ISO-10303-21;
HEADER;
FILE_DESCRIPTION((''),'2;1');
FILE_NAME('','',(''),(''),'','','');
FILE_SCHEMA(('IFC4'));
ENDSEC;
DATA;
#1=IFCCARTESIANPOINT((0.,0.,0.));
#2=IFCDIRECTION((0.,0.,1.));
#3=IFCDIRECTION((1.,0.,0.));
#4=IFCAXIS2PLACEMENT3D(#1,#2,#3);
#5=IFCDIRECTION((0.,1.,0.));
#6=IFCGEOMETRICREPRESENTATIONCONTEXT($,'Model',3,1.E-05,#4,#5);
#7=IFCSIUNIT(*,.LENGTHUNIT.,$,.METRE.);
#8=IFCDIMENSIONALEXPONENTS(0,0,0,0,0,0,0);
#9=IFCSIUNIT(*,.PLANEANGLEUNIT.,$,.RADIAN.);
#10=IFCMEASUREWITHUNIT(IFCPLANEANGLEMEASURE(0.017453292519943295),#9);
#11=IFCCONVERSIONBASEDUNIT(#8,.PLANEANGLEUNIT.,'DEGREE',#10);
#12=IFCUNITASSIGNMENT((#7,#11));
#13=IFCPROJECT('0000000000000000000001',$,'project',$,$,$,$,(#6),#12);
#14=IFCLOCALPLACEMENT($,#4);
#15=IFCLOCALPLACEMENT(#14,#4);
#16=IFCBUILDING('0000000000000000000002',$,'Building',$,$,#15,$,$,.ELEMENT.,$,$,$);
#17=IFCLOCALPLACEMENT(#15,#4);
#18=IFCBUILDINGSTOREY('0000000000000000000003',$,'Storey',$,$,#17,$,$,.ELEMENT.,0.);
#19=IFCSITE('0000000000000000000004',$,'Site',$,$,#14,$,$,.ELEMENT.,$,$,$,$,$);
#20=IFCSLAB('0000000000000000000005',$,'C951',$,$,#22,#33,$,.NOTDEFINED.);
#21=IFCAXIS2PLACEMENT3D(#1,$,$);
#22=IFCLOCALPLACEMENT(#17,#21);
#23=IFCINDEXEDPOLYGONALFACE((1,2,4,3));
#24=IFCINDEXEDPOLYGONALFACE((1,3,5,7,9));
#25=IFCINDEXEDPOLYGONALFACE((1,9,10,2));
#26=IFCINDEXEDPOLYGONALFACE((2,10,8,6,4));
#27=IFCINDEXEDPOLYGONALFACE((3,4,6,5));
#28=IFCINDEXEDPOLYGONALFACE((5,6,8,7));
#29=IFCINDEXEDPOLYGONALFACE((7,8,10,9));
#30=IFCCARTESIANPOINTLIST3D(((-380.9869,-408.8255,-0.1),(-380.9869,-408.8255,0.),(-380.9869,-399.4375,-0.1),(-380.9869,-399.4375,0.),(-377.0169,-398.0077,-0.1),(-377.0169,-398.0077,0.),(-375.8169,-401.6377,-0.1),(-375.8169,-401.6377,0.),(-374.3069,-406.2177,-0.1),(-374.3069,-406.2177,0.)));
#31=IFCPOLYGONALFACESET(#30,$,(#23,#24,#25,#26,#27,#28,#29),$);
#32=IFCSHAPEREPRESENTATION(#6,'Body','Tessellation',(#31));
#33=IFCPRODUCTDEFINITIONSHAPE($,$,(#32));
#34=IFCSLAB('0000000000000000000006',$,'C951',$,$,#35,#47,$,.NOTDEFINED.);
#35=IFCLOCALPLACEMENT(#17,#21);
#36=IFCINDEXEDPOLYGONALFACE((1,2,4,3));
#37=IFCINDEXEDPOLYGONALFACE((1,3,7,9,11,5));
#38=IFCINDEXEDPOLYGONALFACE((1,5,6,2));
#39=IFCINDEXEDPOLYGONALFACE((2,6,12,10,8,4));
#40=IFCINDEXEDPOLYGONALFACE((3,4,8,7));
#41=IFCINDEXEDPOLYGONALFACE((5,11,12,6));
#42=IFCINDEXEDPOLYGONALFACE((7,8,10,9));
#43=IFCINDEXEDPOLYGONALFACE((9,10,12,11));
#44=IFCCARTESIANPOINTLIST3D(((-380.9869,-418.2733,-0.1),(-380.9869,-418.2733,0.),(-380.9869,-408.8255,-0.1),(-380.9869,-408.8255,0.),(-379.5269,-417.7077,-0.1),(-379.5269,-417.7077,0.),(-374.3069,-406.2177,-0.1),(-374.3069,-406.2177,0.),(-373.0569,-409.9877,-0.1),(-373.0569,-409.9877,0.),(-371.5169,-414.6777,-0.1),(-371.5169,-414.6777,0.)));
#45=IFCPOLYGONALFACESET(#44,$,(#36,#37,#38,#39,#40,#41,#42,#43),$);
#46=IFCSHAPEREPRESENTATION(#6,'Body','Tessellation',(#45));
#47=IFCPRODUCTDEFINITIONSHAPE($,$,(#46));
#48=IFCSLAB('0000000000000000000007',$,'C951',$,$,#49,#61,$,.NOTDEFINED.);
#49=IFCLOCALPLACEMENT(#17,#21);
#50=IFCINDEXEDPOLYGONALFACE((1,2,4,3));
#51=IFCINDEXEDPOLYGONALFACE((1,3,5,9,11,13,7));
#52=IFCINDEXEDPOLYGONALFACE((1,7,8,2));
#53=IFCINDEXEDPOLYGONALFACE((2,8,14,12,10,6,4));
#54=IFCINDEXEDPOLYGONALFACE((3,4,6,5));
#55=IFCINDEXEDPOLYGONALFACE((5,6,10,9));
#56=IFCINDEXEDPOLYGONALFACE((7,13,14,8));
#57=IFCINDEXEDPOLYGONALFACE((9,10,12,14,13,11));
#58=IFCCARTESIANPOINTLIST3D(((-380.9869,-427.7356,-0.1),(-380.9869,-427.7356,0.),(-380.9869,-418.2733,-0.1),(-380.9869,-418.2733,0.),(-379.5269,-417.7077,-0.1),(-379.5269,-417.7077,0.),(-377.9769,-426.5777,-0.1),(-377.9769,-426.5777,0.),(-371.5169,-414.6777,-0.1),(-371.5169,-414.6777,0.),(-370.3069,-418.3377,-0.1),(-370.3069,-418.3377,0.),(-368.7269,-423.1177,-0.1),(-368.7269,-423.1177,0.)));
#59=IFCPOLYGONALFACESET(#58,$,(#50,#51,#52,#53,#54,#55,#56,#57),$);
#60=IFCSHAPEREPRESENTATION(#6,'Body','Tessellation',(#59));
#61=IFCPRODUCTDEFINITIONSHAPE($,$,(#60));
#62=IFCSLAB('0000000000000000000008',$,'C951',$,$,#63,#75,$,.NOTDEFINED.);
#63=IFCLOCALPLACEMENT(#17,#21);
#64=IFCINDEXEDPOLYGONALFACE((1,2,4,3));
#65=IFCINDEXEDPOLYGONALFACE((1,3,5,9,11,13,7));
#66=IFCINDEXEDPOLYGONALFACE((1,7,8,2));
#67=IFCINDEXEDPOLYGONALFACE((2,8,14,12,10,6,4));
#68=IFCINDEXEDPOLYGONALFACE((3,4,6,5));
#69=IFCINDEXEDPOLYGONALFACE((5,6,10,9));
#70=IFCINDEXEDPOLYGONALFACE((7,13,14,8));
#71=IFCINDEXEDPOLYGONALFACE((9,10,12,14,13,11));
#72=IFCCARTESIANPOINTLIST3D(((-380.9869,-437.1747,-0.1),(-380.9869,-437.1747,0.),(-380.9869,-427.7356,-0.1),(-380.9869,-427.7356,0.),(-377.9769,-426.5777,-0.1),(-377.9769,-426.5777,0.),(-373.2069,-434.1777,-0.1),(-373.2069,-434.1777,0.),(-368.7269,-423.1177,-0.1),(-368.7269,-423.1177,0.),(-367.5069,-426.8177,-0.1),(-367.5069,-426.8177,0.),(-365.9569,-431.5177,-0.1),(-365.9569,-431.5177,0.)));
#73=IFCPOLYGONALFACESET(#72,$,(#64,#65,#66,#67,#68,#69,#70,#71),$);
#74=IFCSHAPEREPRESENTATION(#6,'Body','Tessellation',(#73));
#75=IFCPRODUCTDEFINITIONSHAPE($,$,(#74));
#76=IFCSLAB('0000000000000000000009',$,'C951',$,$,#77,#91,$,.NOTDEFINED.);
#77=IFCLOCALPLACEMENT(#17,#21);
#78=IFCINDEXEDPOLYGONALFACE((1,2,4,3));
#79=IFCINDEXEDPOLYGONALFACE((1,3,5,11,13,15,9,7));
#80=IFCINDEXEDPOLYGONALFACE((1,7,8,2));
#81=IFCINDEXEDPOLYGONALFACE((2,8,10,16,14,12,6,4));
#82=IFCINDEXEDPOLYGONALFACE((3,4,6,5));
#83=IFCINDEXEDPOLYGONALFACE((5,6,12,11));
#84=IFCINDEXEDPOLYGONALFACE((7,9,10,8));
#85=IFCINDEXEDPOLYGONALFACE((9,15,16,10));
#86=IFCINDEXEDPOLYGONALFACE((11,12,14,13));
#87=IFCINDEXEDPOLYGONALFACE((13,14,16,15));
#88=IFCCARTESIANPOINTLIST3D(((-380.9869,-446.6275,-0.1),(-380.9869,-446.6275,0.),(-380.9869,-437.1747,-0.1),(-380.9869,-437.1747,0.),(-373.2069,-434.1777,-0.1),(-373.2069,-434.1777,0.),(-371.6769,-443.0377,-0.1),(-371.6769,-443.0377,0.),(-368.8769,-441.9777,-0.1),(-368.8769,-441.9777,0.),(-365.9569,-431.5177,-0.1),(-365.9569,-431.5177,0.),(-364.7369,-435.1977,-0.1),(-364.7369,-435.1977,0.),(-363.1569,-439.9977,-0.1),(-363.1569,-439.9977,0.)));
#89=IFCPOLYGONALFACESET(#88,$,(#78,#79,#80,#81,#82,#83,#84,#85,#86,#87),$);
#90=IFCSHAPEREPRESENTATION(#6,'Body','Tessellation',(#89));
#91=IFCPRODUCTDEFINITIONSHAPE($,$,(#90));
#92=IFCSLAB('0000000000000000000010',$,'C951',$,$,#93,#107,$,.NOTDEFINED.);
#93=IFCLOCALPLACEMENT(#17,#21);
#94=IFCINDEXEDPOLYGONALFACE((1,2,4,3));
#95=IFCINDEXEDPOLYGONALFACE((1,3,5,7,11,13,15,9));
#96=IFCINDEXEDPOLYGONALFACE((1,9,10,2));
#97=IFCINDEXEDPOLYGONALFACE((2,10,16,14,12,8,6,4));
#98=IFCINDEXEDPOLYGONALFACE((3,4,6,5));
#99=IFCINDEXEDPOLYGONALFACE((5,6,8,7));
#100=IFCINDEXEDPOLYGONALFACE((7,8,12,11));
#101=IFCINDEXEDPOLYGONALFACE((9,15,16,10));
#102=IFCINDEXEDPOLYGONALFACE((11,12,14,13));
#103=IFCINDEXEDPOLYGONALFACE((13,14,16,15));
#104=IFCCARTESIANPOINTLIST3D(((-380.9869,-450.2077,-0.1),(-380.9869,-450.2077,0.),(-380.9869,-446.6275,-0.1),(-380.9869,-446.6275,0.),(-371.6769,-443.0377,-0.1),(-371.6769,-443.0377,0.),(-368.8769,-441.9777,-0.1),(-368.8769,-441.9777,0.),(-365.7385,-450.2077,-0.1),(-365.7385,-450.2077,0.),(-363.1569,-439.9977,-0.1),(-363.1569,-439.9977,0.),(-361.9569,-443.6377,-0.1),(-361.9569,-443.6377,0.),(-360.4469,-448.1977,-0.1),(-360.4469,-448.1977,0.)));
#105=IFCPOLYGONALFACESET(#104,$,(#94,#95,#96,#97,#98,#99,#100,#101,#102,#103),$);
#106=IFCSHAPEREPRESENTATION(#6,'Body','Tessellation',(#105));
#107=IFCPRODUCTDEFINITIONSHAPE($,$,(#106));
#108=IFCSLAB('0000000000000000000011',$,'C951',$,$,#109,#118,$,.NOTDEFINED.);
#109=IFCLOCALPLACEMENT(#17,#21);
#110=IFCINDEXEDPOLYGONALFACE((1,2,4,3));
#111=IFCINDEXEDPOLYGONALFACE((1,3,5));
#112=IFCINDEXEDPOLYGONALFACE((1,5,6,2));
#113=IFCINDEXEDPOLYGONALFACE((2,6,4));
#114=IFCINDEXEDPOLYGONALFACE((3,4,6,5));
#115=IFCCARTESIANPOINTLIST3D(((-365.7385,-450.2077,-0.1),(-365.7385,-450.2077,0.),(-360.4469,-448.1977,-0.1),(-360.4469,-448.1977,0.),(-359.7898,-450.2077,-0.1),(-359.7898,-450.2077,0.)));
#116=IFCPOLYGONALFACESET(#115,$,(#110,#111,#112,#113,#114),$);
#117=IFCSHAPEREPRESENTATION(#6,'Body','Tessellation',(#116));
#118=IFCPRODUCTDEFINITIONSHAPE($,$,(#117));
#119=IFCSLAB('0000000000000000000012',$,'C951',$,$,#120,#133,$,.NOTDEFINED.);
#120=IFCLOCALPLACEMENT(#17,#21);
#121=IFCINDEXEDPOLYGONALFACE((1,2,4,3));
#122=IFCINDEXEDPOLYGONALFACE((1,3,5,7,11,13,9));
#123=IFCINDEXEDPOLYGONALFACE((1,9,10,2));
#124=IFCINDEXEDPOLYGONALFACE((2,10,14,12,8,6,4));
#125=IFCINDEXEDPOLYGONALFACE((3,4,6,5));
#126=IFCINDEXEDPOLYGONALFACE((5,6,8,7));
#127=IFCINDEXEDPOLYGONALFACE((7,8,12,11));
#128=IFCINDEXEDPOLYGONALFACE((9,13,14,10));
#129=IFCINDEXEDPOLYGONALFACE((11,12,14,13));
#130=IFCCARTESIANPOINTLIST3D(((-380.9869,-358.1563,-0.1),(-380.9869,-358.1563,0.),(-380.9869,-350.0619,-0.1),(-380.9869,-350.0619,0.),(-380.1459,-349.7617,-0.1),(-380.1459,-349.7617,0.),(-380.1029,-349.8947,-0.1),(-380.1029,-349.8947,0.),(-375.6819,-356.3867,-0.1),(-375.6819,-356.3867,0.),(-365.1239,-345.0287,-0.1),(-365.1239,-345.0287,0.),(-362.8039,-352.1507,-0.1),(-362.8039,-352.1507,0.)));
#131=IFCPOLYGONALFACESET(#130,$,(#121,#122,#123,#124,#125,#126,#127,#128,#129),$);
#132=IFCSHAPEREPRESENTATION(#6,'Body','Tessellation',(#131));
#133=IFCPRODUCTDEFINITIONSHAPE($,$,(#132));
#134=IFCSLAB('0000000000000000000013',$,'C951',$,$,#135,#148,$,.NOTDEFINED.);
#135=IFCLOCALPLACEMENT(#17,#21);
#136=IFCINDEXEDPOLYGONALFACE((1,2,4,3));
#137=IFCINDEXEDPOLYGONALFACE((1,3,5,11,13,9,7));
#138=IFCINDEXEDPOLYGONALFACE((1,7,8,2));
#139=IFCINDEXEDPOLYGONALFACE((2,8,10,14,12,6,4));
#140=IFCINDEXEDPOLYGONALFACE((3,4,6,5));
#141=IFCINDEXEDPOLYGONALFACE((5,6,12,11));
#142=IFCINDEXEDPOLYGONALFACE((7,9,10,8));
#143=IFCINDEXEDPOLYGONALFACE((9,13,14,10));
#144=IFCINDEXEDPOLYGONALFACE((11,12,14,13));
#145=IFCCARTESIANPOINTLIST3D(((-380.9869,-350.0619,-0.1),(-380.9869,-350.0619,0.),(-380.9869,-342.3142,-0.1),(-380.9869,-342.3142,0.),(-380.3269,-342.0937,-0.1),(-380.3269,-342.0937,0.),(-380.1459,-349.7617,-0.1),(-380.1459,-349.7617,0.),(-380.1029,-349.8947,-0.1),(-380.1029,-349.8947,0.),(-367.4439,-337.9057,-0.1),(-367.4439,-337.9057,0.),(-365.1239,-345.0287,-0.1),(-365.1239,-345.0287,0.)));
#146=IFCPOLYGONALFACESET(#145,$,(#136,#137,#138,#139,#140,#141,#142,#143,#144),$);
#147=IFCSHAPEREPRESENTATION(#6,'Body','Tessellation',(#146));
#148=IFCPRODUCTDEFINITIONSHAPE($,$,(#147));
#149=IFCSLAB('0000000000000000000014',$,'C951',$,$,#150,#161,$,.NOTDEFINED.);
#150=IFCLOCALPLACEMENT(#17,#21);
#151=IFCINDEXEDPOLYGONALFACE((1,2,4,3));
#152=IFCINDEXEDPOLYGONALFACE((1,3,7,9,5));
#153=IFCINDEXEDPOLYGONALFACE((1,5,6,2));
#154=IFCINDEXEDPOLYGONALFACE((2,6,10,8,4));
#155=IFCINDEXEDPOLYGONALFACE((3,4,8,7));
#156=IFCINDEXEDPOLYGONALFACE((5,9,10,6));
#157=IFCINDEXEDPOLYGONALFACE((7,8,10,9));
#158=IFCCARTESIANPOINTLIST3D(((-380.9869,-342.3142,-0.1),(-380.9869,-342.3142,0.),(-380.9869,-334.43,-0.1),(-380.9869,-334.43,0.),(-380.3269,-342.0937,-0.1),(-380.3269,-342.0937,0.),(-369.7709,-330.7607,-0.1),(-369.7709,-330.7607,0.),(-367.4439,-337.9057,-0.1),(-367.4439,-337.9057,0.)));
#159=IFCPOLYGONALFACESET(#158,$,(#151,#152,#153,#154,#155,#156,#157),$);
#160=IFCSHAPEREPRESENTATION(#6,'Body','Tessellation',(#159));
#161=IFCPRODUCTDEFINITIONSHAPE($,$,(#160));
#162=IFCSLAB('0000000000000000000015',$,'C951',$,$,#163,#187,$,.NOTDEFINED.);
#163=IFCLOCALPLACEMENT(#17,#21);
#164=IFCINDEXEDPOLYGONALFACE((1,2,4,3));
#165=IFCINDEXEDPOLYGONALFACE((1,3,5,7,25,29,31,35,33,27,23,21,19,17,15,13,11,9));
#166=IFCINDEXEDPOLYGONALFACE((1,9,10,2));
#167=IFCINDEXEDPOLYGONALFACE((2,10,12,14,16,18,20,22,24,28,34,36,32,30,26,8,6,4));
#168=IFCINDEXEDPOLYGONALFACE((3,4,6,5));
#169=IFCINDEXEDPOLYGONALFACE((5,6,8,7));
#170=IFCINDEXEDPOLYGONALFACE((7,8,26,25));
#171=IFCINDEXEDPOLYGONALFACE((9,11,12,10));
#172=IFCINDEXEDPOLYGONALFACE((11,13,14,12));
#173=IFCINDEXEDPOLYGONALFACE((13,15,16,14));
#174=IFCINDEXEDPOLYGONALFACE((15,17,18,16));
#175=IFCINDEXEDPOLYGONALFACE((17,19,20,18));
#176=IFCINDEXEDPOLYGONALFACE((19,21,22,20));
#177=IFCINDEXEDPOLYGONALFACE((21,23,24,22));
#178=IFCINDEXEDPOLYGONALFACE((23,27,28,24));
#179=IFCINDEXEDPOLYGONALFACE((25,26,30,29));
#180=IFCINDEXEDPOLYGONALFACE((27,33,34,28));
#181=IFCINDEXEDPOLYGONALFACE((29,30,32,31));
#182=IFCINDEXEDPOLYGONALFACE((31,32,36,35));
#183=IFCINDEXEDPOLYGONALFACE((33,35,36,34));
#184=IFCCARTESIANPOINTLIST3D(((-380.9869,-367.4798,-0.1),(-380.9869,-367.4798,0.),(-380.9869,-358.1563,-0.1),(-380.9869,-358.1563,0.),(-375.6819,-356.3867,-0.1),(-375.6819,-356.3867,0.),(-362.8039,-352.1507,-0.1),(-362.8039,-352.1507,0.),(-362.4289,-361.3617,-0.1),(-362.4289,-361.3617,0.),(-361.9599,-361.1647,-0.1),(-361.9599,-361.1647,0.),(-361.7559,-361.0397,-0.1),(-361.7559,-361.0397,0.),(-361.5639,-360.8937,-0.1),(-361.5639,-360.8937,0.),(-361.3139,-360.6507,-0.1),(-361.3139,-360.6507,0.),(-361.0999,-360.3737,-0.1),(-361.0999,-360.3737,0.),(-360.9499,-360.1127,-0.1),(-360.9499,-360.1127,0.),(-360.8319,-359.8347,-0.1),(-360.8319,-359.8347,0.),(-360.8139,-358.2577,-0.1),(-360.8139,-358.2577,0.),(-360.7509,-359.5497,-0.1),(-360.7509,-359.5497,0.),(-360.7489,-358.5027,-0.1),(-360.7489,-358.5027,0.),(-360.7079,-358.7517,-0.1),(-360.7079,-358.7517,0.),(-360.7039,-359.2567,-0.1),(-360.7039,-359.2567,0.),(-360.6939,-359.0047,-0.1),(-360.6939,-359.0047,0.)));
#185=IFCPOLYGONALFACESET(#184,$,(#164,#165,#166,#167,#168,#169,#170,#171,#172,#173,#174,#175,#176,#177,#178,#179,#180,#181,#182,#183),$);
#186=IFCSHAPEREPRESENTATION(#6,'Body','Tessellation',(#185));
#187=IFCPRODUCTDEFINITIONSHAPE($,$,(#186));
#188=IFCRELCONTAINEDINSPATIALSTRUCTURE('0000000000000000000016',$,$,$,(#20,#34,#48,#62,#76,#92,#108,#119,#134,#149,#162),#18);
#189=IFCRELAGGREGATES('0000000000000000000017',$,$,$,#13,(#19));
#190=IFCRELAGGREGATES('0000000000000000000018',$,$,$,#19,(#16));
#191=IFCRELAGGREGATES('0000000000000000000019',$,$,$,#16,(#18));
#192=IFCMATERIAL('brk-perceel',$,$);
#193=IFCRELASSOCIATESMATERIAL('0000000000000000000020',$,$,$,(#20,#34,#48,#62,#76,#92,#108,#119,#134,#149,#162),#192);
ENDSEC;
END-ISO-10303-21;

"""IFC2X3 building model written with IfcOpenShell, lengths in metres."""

from ifc_helpers import new_model, entity, si_unit, converted_unit, direction, frame, origin_with_axes, place, context, project, spatial, polyline, outline, extrude, material, element, save


model = new_model("IFC2X3")

# Units and contexts
model_context = context("Model", 3, precision=1e-05, world=origin_with_axes(), true_north=direction((0.0, 1.0, 0.0)))
ifc_project = project(units=[si_unit("LENGTHUNIT", "METRE"), converted_unit("PLANEANGLEUNIT", "DEGREE", entity("IfcPlaneAngleMeasure", 0.017453292519943295), si_unit("PLANEANGLEUNIT", "RADIAN"), dimensions=[0, 0, 0, 0, 0, 0, 0])], contexts=[model_context])

# Site, building, storey
site_placement = place(None, origin_with_axes())
site = spatial("IfcSite", under=ifc_project, at=site_placement, Name="Site", CompositionType="ELEMENT")
building_placement = place(site_placement, origin_with_axes())
building = spatial("IfcBuilding", under=site, at=building_placement, Name="Building", CompositionType="ELEMENT")
storey_placement = place(building_placement, origin_with_axes())
storey = spatial("IfcBuildingStorey", under=building, at=storey_placement, Name="Storey", CompositionType="ELEMENT", Elevation=0.0)

# Slabs
ifc_material = material(Name="brk-perceel")
slab_1_placement = place(storey_placement, frame((0.0, 0.0, -0.1), z_axis=(0.0, 0.0, 1.0), x_axis=(1.0, 0.0, 0.0)))
element("IfcSlab", 1, at=slab_1_placement, inside=storey, material=ifc_material, Name="C951", PredefinedType="NOTDEFINED", context=model_context, shape_type="SweptSolid", body=[
    extrude(outline(polyline([(-377.0169, -398.0077), (-375.8169, -401.6377), (-374.3069, -406.2177), (-380.9869, -408.8255), (-380.9869, -399.4375), (-377.0169, -398.0077)])), origin_with_axes(), (0.0, 0.0, 1.0), 0.1),
])
slab_2_placement = place(storey_placement, frame((0.0, 0.0, -0.1), z_axis=(0.0, 0.0, 1.0), x_axis=(1.0, 0.0, 0.0)))
element("IfcSlab", 2, at=slab_2_placement, inside=storey, material=ifc_material, Name="C951", PredefinedType="NOTDEFINED", context=model_context, shape_type="SweptSolid", body=[
    extrude(outline(polyline([(-374.3069, -406.2177), (-373.0569, -409.9877), (-371.5169, -414.6777), (-379.5269, -417.7077), (-380.9869, -418.2733), (-380.9869, -408.8255), (-374.3069, -406.2177)])), origin_with_axes(), (0.0, 0.0, 1.0), 0.1),
])
slab_3_placement = place(storey_placement, frame((0.0, 0.0, -0.1), z_axis=(0.0, 0.0, 1.0), x_axis=(1.0, 0.0, 0.0)))
element("IfcSlab", 3, at=slab_3_placement, inside=storey, material=ifc_material, Name="C951", PredefinedType="NOTDEFINED", context=model_context, shape_type="SweptSolid", body=[
    extrude(outline(polyline([(-379.5269, -417.7077), (-371.5169, -414.6777), (-370.3069, -418.3377), (-368.7269, -423.1177), (-377.9769, -426.5777), (-380.9869, -427.7356), (-380.9869, -418.2733), (-379.5269, -417.7077)])), origin_with_axes(), (0.0, 0.0, 1.0), 0.1),
])
slab_4_placement = place(storey_placement, frame((0.0, 0.0, -0.1), z_axis=(0.0, 0.0, 1.0), x_axis=(1.0, 0.0, 0.0)))
element("IfcSlab", 4, at=slab_4_placement, inside=storey, material=ifc_material, Name="C951", PredefinedType="NOTDEFINED", context=model_context, shape_type="SweptSolid", body=[
    extrude(outline(polyline([(-377.9769, -426.5777), (-368.7269, -423.1177), (-367.5069, -426.8177), (-365.9569, -431.5177), (-373.2069, -434.1777), (-380.9869, -437.1747), (-380.9869, -427.7356), (-377.9769, -426.5777)])), origin_with_axes(), (0.0, 0.0, 1.0), 0.1),
])
slab_5_placement = place(storey_placement, frame((0.0, 0.0, -0.1), z_axis=(0.0, 0.0, 1.0), x_axis=(1.0, 0.0, 0.0)))
element("IfcSlab", 5, at=slab_5_placement, inside=storey, material=ifc_material, Name="C951", PredefinedType="NOTDEFINED", context=model_context, shape_type="SweptSolid", body=[
    extrude(outline(polyline([(-373.2069, -434.1777), (-365.9569, -431.5177), (-364.7369, -435.1977), (-363.1569, -439.9977), (-368.8769, -441.9777), (-371.6769, -443.0377), (-380.9869, -446.6275), (-380.9869, -437.1747), (-373.2069, -434.1777)])), origin_with_axes(), (0.0, 0.0, 1.0), 0.1),
])
slab_6_placement = place(storey_placement, frame((0.0, 0.0, -0.1), z_axis=(0.0, 0.0, 1.0), x_axis=(1.0, 0.0, 0.0)))
element("IfcSlab", 6, at=slab_6_placement, inside=storey, material=ifc_material, Name="C951", PredefinedType="NOTDEFINED", context=model_context, shape_type="SweptSolid", body=[
    extrude(outline(polyline([(-371.6769, -443.0377), (-368.8769, -441.9777), (-363.1569, -439.9977), (-361.9569, -443.6377), (-360.4469, -448.1977), (-365.7385, -450.2077), (-380.9869, -450.2077), (-380.9869, -446.6275), (-371.6769, -443.0377)])), origin_with_axes(), (0.0, 0.0, 1.0), 0.1),
])
slab_7_placement = place(storey_placement, frame((0.0, 0.0, -0.1), z_axis=(0.0, 0.0, 1.0), x_axis=(1.0, 0.0, 0.0)))
element("IfcSlab", 7, at=slab_7_placement, inside=storey, material=ifc_material, Name="C951", PredefinedType="NOTDEFINED", context=model_context, shape_type="SweptSolid", body=[
    extrude(outline(polyline([(-360.4469, -448.1977), (-359.7898, -450.2077), (-365.7385, -450.2077), (-360.4469, -448.1977)])), origin_with_axes(), (0.0, 0.0, 1.0), 0.1),
])
slab_8_placement = place(storey_placement, frame((0.0, 0.0, -0.1), z_axis=(0.0, 0.0, 1.0), x_axis=(1.0, 0.0, 0.0)))
element("IfcSlab", 8, at=slab_8_placement, inside=storey, material=ifc_material, Name="C951", PredefinedType="NOTDEFINED", context=model_context, shape_type="SweptSolid", body=[
    extrude(outline(polyline([(-380.1459, -349.7617), (-380.1029, -349.8947), (-365.1239, -345.0287), (-362.8039, -352.1507), (-375.6819, -356.3867), (-380.9869, -358.1563), (-380.9869, -350.0619), (-380.1459, -349.7617)])), origin_with_axes(), (0.0, 0.0, 1.0), 0.1),
])
slab_9_placement = place(storey_placement, frame((0.0, 0.0, -0.1), z_axis=(0.0, 0.0, 1.0), x_axis=(1.0, 0.0, 0.0)))
element("IfcSlab", 9, at=slab_9_placement, inside=storey, material=ifc_material, Name="C951", PredefinedType="NOTDEFINED", context=model_context, shape_type="SweptSolid", body=[
    extrude(outline(polyline([(-380.3269, -342.0937), (-367.4439, -337.9057), (-365.1239, -345.0287), (-380.1029, -349.8947), (-380.1459, -349.7617), (-380.9869, -350.0619), (-380.9869, -342.3142), (-380.3269, -342.0937)])), origin_with_axes(), (0.0, 0.0, 1.0), 0.1),
])
slab_10_placement = place(storey_placement, frame((0.0, 0.0, -0.1), z_axis=(0.0, 0.0, 1.0), x_axis=(1.0, 0.0, 0.0)))
element("IfcSlab", 10, at=slab_10_placement, inside=storey, material=ifc_material, Name="C951", PredefinedType="NOTDEFINED", context=model_context, shape_type="SweptSolid", body=[
    extrude(outline(polyline([(-369.7709, -330.7607), (-367.4439, -337.9057), (-380.3269, -342.0937), (-380.9869, -342.3142), (-380.9869, -334.43), (-369.7709, -330.7607)])), origin_with_axes(), (0.0, 0.0, 1.0), 0.1),
])
slab_11_placement = place(storey_placement, frame((0.0, 0.0, -0.1), z_axis=(0.0, 0.0, 1.0), x_axis=(1.0, 0.0, 0.0)))
element("IfcSlab", 11, at=slab_11_placement, inside=storey, material=ifc_material, Name="C951", PredefinedType="NOTDEFINED", context=model_context, shape_type="SweptSolid", body=[
    extrude(outline(polyline([(-375.6819, -356.3867), (-362.8039, -352.1507), (-360.8139, -358.2577), (-360.7489, -358.5027), (-360.7079, -358.7517), (-360.6939, -359.0047), (-360.7039, -359.2567), (-360.7509, -359.5497), (-360.8319, -359.8347), (-360.9499, -360.1127), (-361.0999, -360.3737), (-361.3139, -360.6507), (-361.5639, -360.8937), (-361.7559, -361.0397), (-361.9599, -361.1647), (-362.4289, -361.3617), (-380.9869, -367.4798), (-380.9869, -358.1563), (-375.6819, -356.3867)])), origin_with_axes(), (0.0, 0.0, 1.0), 0.1),
])

save(model, "model.ifc")
